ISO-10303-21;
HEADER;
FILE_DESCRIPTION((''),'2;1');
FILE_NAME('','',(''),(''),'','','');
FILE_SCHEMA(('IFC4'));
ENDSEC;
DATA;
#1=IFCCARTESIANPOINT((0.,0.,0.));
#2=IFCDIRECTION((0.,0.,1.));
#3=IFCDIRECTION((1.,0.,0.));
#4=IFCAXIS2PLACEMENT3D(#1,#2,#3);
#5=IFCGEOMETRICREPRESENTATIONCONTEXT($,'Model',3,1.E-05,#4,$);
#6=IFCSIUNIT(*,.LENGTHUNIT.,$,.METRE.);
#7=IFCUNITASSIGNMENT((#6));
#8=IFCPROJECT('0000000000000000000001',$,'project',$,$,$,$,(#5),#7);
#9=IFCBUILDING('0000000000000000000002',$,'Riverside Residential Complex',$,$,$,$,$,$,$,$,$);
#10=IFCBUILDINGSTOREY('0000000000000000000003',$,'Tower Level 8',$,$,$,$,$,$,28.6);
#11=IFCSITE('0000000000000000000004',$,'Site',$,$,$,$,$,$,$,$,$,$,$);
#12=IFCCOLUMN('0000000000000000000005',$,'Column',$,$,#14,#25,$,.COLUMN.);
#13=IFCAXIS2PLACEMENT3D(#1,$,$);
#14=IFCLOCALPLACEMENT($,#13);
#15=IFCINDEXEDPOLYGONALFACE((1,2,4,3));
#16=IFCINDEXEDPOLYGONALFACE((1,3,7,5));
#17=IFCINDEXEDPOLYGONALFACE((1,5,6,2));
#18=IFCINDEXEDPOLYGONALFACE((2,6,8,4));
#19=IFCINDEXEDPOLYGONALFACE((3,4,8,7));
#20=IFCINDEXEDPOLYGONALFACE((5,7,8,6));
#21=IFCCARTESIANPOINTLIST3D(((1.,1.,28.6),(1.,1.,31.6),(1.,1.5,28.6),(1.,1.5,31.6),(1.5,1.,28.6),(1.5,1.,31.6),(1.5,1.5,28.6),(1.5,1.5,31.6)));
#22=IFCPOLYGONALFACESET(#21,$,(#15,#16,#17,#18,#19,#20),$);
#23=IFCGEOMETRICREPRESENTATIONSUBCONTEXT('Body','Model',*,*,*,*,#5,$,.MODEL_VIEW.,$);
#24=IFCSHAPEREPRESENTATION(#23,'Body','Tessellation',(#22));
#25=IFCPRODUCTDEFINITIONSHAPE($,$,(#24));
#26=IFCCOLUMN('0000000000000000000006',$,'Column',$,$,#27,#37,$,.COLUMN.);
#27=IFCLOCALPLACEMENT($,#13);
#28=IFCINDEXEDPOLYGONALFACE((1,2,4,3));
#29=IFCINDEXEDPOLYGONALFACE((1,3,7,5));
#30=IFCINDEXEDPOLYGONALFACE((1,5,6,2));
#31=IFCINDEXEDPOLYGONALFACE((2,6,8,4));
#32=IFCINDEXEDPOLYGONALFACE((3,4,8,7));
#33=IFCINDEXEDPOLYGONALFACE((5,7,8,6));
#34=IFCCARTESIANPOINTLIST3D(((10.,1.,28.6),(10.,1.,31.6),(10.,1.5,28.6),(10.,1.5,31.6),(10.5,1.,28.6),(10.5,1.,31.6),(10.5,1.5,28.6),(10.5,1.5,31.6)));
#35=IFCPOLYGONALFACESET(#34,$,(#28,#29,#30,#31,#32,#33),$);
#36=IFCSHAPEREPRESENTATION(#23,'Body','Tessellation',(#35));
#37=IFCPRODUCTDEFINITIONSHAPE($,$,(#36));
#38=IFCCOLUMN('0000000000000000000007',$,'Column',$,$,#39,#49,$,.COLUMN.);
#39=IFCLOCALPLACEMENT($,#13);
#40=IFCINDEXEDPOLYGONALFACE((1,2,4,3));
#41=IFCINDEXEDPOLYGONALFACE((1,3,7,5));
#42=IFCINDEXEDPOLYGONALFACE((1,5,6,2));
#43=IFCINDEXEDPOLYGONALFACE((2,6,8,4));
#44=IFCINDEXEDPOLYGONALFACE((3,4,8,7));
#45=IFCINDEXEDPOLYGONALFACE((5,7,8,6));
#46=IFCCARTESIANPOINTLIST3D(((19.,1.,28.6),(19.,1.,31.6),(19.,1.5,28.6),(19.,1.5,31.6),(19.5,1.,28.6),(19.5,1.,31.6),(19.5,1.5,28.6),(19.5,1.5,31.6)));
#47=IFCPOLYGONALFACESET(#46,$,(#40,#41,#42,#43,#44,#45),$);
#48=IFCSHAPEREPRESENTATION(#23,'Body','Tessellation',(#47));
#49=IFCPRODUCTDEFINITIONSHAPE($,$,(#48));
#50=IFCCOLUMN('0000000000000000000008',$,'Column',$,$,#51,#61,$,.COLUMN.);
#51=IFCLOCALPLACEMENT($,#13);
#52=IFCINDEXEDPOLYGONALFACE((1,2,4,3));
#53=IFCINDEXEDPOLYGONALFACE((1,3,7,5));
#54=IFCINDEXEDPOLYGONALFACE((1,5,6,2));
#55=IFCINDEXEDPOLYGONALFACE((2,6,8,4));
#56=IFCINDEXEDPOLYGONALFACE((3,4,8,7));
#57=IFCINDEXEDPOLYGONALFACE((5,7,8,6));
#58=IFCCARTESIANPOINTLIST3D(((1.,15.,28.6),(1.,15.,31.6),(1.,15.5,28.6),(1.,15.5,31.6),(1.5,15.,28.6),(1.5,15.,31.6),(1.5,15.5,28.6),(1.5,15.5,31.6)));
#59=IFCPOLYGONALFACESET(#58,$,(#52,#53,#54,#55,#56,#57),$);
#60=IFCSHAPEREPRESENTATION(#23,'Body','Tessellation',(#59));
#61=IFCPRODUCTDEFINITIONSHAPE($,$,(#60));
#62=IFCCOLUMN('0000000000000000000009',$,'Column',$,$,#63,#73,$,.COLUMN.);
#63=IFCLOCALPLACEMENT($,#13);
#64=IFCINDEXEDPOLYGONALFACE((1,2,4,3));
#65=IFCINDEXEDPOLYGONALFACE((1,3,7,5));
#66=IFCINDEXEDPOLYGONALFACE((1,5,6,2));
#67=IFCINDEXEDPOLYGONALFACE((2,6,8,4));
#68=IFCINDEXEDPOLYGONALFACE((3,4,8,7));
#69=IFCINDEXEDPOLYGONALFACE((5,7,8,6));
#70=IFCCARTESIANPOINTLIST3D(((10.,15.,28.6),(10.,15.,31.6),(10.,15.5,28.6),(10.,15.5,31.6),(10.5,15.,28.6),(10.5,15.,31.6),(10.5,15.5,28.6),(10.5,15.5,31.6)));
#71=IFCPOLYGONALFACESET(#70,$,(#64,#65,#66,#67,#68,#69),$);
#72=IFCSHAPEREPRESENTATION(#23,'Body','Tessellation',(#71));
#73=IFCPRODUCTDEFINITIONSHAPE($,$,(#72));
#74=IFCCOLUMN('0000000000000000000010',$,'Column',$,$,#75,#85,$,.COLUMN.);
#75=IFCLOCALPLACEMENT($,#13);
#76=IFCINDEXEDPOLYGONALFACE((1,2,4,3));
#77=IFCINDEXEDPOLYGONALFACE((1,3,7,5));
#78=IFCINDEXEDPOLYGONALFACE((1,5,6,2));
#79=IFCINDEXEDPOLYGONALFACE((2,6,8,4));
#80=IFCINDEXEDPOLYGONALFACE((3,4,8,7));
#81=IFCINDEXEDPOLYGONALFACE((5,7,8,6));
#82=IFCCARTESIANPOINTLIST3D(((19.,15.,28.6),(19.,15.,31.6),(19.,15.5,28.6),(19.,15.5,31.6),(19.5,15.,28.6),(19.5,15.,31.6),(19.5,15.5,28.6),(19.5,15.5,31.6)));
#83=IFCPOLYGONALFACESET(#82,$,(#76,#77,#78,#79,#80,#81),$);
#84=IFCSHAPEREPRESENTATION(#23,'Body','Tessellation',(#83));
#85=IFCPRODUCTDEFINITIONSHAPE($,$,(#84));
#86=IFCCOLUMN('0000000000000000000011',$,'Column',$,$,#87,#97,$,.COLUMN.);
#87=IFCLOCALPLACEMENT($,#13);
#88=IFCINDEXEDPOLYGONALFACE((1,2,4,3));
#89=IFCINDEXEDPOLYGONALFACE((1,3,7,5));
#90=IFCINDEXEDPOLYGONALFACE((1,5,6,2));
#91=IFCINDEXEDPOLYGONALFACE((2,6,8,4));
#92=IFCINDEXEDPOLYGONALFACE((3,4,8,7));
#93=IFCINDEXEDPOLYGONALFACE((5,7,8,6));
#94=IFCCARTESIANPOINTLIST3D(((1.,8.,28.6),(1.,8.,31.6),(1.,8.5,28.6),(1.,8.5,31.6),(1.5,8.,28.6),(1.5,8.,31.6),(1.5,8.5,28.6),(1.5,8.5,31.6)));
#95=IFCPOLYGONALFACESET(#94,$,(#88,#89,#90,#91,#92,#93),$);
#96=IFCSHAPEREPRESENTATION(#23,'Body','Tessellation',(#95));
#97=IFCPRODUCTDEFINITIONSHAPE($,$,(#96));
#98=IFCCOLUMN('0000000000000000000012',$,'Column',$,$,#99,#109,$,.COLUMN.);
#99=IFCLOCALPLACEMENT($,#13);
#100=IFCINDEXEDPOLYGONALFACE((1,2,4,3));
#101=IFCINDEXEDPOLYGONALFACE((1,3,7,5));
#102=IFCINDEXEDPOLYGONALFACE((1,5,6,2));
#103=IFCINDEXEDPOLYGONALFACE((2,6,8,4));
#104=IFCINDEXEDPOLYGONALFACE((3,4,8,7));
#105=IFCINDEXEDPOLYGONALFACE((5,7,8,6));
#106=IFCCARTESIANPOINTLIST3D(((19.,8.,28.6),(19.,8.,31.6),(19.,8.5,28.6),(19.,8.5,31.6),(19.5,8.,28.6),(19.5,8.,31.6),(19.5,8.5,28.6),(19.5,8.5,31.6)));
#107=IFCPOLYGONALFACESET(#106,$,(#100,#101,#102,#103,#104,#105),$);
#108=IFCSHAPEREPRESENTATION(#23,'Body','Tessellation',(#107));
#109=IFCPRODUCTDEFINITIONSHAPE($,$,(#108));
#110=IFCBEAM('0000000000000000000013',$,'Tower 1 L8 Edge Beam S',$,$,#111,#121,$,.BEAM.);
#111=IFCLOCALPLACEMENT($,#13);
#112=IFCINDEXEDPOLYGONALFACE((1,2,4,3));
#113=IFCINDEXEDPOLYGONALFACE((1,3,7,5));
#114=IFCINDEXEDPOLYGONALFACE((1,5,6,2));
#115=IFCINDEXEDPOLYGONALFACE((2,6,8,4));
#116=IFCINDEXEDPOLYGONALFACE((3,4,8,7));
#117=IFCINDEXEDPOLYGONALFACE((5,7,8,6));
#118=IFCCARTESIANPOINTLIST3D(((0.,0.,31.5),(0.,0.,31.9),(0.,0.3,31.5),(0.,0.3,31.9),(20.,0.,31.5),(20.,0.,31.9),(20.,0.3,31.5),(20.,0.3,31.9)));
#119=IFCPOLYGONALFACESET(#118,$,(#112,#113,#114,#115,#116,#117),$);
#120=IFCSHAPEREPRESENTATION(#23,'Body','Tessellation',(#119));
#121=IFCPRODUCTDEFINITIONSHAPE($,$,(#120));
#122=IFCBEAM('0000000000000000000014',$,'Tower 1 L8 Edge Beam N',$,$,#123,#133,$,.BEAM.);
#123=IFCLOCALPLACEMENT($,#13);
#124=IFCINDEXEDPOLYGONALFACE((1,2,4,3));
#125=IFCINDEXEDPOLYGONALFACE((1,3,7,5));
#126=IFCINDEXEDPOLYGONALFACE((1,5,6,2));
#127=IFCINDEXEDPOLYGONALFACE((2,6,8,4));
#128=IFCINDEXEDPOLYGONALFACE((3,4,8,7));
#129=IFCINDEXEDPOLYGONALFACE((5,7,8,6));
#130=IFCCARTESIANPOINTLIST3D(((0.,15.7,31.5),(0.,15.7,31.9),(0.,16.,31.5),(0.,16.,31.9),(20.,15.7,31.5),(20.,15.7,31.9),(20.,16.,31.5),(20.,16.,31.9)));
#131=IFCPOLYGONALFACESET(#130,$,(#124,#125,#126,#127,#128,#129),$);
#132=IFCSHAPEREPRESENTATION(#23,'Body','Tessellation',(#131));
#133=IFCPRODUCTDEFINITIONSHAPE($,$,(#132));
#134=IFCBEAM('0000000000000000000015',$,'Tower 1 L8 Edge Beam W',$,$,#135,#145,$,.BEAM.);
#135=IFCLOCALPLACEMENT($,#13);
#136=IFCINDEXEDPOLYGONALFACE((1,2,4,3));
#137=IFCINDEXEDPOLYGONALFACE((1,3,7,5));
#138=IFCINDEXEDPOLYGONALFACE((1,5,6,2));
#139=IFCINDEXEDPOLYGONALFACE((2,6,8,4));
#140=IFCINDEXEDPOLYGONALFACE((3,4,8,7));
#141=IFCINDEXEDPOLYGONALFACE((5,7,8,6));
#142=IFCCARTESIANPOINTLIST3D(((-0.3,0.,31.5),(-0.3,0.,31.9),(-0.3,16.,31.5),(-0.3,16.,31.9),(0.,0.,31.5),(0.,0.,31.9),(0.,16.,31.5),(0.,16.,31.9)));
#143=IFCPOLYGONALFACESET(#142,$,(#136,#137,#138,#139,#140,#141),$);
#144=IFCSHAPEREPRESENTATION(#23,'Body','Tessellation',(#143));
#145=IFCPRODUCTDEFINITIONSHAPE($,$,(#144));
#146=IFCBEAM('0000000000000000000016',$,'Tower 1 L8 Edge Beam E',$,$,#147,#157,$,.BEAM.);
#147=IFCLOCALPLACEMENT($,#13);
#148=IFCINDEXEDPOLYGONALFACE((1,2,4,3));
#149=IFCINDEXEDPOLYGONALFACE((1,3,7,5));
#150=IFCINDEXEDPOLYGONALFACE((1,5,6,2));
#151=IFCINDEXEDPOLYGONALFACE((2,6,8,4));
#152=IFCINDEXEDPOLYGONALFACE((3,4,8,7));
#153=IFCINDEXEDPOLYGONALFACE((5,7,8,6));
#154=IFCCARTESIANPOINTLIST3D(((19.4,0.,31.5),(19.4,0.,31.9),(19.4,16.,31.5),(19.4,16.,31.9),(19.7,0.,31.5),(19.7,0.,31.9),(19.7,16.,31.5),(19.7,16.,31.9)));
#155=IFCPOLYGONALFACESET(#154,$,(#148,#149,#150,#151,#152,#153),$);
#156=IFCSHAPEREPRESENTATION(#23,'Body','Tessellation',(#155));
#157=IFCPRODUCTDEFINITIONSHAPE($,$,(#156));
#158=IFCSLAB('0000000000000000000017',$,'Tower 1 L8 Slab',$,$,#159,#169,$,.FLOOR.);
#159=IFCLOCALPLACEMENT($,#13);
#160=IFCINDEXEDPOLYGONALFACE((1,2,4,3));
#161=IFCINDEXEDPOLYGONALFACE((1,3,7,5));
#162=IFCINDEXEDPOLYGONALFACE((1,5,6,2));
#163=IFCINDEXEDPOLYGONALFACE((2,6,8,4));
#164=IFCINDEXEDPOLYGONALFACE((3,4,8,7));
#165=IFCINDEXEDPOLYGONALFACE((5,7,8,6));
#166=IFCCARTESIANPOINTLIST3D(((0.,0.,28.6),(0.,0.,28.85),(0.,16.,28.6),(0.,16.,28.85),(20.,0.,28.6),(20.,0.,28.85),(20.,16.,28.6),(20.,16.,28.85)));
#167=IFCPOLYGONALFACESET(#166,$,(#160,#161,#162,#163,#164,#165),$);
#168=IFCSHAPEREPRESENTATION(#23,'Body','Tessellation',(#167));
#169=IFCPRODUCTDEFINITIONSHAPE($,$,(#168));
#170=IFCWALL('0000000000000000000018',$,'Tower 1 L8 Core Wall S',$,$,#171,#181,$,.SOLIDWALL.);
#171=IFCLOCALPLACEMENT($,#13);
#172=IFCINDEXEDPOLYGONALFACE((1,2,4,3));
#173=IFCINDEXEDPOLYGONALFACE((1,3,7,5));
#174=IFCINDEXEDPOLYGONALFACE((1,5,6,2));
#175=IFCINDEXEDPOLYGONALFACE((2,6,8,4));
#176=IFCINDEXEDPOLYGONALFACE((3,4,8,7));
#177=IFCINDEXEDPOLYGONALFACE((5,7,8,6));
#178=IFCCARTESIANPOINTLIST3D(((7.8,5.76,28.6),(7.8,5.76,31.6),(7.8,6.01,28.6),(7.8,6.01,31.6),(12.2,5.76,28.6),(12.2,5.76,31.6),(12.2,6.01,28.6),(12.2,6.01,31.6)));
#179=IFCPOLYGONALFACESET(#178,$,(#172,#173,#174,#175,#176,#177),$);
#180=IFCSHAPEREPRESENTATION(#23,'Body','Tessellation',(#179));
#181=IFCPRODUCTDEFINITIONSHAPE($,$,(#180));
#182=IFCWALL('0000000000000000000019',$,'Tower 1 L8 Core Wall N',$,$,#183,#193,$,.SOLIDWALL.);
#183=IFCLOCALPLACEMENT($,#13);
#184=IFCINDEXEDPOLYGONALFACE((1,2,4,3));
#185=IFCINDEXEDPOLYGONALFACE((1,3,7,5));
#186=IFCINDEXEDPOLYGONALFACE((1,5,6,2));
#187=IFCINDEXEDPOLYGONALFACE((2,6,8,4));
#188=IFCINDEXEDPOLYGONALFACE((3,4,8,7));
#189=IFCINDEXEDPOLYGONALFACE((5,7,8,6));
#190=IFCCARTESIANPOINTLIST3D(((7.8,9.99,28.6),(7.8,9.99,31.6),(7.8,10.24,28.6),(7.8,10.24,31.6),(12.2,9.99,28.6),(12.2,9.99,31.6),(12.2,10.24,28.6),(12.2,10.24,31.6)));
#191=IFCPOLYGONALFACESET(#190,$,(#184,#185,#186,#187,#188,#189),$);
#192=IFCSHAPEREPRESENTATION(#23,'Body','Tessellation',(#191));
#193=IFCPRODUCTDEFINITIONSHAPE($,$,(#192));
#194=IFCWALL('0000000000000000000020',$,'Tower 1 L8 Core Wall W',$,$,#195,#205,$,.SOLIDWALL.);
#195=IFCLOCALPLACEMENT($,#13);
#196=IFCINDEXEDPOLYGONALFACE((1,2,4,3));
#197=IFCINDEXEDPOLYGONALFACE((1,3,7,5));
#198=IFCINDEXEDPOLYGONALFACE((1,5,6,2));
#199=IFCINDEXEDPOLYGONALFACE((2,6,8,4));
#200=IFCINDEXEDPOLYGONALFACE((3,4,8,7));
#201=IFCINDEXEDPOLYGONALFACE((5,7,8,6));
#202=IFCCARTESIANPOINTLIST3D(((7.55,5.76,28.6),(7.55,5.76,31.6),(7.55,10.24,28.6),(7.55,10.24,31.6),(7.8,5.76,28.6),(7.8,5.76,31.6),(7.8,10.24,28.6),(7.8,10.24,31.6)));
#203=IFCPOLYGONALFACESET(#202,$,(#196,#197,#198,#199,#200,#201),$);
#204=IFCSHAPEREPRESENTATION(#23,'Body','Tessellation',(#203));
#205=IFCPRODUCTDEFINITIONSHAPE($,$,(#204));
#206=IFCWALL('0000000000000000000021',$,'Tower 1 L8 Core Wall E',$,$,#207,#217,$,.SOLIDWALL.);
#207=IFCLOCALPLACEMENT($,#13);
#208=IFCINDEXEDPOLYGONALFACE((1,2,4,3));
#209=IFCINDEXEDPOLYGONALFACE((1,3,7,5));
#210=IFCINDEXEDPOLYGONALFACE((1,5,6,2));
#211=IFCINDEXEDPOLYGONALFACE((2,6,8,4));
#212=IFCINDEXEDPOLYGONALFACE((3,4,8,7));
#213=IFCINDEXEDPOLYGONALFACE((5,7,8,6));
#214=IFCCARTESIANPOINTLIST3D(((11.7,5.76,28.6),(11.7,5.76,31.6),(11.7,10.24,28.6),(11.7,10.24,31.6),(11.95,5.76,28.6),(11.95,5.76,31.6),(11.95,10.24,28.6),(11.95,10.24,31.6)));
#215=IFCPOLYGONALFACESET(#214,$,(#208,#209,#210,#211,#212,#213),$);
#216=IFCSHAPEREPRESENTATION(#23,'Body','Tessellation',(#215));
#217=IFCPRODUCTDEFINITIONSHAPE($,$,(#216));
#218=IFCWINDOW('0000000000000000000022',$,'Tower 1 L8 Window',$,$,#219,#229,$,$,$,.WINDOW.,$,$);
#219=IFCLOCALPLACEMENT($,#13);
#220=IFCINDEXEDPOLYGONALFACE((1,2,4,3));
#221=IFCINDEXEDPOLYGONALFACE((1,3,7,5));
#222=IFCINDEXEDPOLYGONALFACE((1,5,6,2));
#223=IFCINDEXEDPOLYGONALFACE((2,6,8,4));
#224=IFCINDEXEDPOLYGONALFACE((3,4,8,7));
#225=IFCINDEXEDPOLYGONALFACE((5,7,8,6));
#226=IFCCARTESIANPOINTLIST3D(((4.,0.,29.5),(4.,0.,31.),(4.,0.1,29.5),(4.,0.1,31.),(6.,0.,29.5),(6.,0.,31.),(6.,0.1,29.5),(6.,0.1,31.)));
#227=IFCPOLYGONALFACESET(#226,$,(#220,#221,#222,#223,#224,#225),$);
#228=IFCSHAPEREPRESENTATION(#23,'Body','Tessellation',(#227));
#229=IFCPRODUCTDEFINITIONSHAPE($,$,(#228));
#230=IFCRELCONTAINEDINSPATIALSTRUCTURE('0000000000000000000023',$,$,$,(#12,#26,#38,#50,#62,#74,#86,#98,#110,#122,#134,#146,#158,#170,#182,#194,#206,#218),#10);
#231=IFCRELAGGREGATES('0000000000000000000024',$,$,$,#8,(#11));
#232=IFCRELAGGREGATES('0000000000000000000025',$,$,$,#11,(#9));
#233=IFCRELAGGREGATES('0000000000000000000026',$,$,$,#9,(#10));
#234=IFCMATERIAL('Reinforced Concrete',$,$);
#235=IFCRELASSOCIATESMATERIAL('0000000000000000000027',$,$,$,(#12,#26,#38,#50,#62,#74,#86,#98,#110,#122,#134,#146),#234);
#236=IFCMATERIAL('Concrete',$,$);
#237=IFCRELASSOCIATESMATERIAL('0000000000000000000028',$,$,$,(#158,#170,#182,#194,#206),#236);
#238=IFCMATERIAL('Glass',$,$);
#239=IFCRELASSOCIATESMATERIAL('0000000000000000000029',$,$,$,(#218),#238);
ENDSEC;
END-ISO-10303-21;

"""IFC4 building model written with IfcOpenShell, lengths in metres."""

from ifc_helpers import new_model, si_unit, frame, origin_with_axes, place, context, subcontext, project, spatial, line, indexed_curve, outline, extrude, material, element, save


model = new_model("IFC4")

# Units and contexts
model_context = context("Model", 3, precision=1e-05, world=origin_with_axes())
body_context = subcontext(model_context, "Body", "Model", "MODEL_VIEW")
ifc_project = project(units=[si_unit("LENGTHUNIT", "METRE")], contexts=[model_context])

# Site, building, storey
site = spatial("IfcSite", under=ifc_project, Name="Site")
building = spatial("IfcBuilding", under=site, Name="Riverside Residential Complex")
storey = spatial("IfcBuildingStorey", under=building, Name="Tower Level 8", Elevation=28.6)

# Columns
ifc_material_1 = material(Name="Reinforced Concrete")
for number, where, z_axis, x_axis, name in (
    (1, (1.0, 1.0, 28.6), (0.0, 0.0, 1.0), (1.0, 0.0, 0.0), "Column"),
    (2, (10.0, 1.0, 28.6), (0.0, 0.0, 1.0), (1.0, 0.0, 0.0), "Column"),
    (3, (19.0, 1.0, 28.6), (0.0, 0.0, 1.0), (1.0, 0.0, 0.0), "Column"),
    (4, (1.0, 15.0, 28.6), (0.0, 0.0, 1.0), (1.0, 0.0, 0.0), "Column"),
    (5, (10.0, 15.0, 28.6), (0.0, 0.0, 1.0), (1.0, 0.0, 0.0), "Column"),
    (6, (19.0, 15.0, 28.6), (0.0, 0.0, 1.0), (1.0, 0.0, 0.0), "Column"),
    (7, (1.0, 8.0, 28.6), (0.0, 0.0, 1.0), (1.0, 0.0, 0.0), "Column"),
    (8, (19.0, 8.0, 28.6), (0.0, 0.0, 1.0), (1.0, 0.0, 0.0), "Column"),
):
    element("IfcColumn", number, at=place(None, frame(where, z_axis=z_axis, x_axis=x_axis)), inside=storey, material=ifc_material_1, Name=name, PredefinedType="COLUMN", context=body_context, shape_type="SweptSolid", body=[
        extrude(outline(indexed_curve([(0.0, 0.0), (0.5, 0.0), (0.5, 0.5), (0.0, 0.5)], segments=[line(1, 2, 3, 4, 1)])), origin_with_axes(), (0.0, 0.0, 1.0), 3.0),
    ])

# Beams
for number, where, z_axis, x_axis, name in (
    (9, (0.0, 0.0, 31.5), (0.0, 0.0, 1.0), (1.0, 0.0, 0.0), "Tower 1 L8 Edge Beam S"),
    (10, (0.0, 15.7, 31.5), (0.0, 0.0, 1.0), (1.0, 0.0, 0.0), "Tower 1 L8 Edge Beam N"),
):
    element("IfcBeam", number, at=place(None, frame(where, z_axis=z_axis, x_axis=x_axis)), inside=storey, material=ifc_material_1, Name=name, PredefinedType="BEAM", context=body_context, shape_type="SweptSolid", body=[
        extrude(outline(indexed_curve([(0.0, 0.0), (20.0, 0.0), (20.0, 0.3), (0.0, 0.3)], segments=[line(1, 2, 3, 4, 1)])), origin_with_axes(), (0.0, 0.0, 1.0), 0.4),
    ])
for number, where, z_axis, x_axis, name in (
    (11, (0.0, 0.0, 31.5), (0.0, 0.0, 1.0), (0.0, 1.0, 0.0), "Tower 1 L8 Edge Beam W"),
    (12, (19.7, 0.0, 31.5), (0.0, 0.0, 1.0), (0.0, 1.0, 0.0), "Tower 1 L8 Edge Beam E"),
):
    element("IfcBeam", number, at=place(None, frame(where, z_axis=z_axis, x_axis=x_axis)), inside=storey, material=ifc_material_1, Name=name, PredefinedType="BEAM", context=body_context, shape_type="SweptSolid", body=[
        extrude(outline(indexed_curve([(0.0, 0.0), (16.0, 0.0), (16.0, 0.3), (0.0, 0.3)], segments=[line(1, 2, 3, 4, 1)])), origin_with_axes(), (0.0, 0.0, 1.0), 0.4),
    ])

# Slab
ifc_material_2 = material(Name="Concrete")
slab_placement = place(None, frame((0.0, 0.0, 28.6), z_axis=(0.0, 0.0, 1.0), x_axis=(1.0, 0.0, 0.0)))
element("IfcSlab", 13, at=slab_placement, inside=storey, material=ifc_material_2, Name="Tower 1 L8 Slab", PredefinedType="FLOOR", context=body_context, shape_type="SweptSolid", body=[
    extrude(outline(indexed_curve([(0.0, 0.0), (20.0, 0.0), (20.0, 16.0), (0.0, 16.0)], segments=[line(1, 2, 3, 4, 1)])), origin_with_axes(), (0.0, 0.0, 1.0), 0.25),
])

# Walls
for number, where, z_axis, x_axis, name in (
    (14, (7.8, 5.76, 28.6), (0.0, 0.0, 1.0), (1.0, 0.0, 0.0), "Tower 1 L8 Core Wall S"),
    (15, (7.8, 9.99, 28.6), (0.0, 0.0, 1.0), (1.0, 0.0, 0.0), "Tower 1 L8 Core Wall N"),
):
    element("IfcWall", number, at=place(None, frame(where, z_axis=z_axis, x_axis=x_axis)), inside=storey, material=ifc_material_2, Name=name, PredefinedType="SOLIDWALL", context=body_context, shape_type="SweptSolid", body=[
        extrude(outline(indexed_curve([(0.0, 0.0), (4.4, 0.0), (4.4, 0.25), (0.0, 0.25)], segments=[line(1, 2, 3, 4, 1)])), origin_with_axes(), (0.0, 0.0, 1.0), 3.0),
    ])
for number, where, z_axis, x_axis, name in (
    (16, (7.8, 5.76, 28.6), (0.0, 0.0, 1.0), (0.0, 1.0, 0.0), "Tower 1 L8 Core Wall W"),
    (17, (11.95, 5.76, 28.6), (0.0, 0.0, 1.0), (0.0, 1.0, 0.0), "Tower 1 L8 Core Wall E"),
):
    element("IfcWall", number, at=place(None, frame(where, z_axis=z_axis, x_axis=x_axis)), inside=storey, material=ifc_material_2, Name=name, PredefinedType="SOLIDWALL", context=body_context, shape_type="SweptSolid", body=[
        extrude(outline(indexed_curve([(0.0, 0.0), (4.48, 0.0), (4.48, 0.25), (0.0, 0.25)], segments=[line(1, 2, 3, 4, 1)])), origin_with_axes(), (0.0, 0.0, 1.0), 3.0),
    ])

# Window
ifc_material_3 = material(Name="Glass")
for number, where, z_axis, x_axis, name in (
    (18, (4.0, 0.0, 29.5), (0.0, 0.0, 1.0), (1.0, 0.0, 0.0), "Tower 1 L8 Window"),
):
    element("IfcWindow", number, at=place(None, frame(where, z_axis=z_axis, x_axis=x_axis)), inside=storey, material=ifc_material_3, Name=name, PredefinedType="WINDOW", context=body_context, shape_type="SweptSolid", body=[
        extrude(outline(indexed_curve([(0.0, 0.0), (2.0, 0.0), (2.0, 0.1), (0.0, 0.1)], segments=[line(1, 2, 3, 4, 1)])), origin_with_axes(), (0.0, 0.0, 1.0), 1.5),
    ])

save(model, "model.ifc")
